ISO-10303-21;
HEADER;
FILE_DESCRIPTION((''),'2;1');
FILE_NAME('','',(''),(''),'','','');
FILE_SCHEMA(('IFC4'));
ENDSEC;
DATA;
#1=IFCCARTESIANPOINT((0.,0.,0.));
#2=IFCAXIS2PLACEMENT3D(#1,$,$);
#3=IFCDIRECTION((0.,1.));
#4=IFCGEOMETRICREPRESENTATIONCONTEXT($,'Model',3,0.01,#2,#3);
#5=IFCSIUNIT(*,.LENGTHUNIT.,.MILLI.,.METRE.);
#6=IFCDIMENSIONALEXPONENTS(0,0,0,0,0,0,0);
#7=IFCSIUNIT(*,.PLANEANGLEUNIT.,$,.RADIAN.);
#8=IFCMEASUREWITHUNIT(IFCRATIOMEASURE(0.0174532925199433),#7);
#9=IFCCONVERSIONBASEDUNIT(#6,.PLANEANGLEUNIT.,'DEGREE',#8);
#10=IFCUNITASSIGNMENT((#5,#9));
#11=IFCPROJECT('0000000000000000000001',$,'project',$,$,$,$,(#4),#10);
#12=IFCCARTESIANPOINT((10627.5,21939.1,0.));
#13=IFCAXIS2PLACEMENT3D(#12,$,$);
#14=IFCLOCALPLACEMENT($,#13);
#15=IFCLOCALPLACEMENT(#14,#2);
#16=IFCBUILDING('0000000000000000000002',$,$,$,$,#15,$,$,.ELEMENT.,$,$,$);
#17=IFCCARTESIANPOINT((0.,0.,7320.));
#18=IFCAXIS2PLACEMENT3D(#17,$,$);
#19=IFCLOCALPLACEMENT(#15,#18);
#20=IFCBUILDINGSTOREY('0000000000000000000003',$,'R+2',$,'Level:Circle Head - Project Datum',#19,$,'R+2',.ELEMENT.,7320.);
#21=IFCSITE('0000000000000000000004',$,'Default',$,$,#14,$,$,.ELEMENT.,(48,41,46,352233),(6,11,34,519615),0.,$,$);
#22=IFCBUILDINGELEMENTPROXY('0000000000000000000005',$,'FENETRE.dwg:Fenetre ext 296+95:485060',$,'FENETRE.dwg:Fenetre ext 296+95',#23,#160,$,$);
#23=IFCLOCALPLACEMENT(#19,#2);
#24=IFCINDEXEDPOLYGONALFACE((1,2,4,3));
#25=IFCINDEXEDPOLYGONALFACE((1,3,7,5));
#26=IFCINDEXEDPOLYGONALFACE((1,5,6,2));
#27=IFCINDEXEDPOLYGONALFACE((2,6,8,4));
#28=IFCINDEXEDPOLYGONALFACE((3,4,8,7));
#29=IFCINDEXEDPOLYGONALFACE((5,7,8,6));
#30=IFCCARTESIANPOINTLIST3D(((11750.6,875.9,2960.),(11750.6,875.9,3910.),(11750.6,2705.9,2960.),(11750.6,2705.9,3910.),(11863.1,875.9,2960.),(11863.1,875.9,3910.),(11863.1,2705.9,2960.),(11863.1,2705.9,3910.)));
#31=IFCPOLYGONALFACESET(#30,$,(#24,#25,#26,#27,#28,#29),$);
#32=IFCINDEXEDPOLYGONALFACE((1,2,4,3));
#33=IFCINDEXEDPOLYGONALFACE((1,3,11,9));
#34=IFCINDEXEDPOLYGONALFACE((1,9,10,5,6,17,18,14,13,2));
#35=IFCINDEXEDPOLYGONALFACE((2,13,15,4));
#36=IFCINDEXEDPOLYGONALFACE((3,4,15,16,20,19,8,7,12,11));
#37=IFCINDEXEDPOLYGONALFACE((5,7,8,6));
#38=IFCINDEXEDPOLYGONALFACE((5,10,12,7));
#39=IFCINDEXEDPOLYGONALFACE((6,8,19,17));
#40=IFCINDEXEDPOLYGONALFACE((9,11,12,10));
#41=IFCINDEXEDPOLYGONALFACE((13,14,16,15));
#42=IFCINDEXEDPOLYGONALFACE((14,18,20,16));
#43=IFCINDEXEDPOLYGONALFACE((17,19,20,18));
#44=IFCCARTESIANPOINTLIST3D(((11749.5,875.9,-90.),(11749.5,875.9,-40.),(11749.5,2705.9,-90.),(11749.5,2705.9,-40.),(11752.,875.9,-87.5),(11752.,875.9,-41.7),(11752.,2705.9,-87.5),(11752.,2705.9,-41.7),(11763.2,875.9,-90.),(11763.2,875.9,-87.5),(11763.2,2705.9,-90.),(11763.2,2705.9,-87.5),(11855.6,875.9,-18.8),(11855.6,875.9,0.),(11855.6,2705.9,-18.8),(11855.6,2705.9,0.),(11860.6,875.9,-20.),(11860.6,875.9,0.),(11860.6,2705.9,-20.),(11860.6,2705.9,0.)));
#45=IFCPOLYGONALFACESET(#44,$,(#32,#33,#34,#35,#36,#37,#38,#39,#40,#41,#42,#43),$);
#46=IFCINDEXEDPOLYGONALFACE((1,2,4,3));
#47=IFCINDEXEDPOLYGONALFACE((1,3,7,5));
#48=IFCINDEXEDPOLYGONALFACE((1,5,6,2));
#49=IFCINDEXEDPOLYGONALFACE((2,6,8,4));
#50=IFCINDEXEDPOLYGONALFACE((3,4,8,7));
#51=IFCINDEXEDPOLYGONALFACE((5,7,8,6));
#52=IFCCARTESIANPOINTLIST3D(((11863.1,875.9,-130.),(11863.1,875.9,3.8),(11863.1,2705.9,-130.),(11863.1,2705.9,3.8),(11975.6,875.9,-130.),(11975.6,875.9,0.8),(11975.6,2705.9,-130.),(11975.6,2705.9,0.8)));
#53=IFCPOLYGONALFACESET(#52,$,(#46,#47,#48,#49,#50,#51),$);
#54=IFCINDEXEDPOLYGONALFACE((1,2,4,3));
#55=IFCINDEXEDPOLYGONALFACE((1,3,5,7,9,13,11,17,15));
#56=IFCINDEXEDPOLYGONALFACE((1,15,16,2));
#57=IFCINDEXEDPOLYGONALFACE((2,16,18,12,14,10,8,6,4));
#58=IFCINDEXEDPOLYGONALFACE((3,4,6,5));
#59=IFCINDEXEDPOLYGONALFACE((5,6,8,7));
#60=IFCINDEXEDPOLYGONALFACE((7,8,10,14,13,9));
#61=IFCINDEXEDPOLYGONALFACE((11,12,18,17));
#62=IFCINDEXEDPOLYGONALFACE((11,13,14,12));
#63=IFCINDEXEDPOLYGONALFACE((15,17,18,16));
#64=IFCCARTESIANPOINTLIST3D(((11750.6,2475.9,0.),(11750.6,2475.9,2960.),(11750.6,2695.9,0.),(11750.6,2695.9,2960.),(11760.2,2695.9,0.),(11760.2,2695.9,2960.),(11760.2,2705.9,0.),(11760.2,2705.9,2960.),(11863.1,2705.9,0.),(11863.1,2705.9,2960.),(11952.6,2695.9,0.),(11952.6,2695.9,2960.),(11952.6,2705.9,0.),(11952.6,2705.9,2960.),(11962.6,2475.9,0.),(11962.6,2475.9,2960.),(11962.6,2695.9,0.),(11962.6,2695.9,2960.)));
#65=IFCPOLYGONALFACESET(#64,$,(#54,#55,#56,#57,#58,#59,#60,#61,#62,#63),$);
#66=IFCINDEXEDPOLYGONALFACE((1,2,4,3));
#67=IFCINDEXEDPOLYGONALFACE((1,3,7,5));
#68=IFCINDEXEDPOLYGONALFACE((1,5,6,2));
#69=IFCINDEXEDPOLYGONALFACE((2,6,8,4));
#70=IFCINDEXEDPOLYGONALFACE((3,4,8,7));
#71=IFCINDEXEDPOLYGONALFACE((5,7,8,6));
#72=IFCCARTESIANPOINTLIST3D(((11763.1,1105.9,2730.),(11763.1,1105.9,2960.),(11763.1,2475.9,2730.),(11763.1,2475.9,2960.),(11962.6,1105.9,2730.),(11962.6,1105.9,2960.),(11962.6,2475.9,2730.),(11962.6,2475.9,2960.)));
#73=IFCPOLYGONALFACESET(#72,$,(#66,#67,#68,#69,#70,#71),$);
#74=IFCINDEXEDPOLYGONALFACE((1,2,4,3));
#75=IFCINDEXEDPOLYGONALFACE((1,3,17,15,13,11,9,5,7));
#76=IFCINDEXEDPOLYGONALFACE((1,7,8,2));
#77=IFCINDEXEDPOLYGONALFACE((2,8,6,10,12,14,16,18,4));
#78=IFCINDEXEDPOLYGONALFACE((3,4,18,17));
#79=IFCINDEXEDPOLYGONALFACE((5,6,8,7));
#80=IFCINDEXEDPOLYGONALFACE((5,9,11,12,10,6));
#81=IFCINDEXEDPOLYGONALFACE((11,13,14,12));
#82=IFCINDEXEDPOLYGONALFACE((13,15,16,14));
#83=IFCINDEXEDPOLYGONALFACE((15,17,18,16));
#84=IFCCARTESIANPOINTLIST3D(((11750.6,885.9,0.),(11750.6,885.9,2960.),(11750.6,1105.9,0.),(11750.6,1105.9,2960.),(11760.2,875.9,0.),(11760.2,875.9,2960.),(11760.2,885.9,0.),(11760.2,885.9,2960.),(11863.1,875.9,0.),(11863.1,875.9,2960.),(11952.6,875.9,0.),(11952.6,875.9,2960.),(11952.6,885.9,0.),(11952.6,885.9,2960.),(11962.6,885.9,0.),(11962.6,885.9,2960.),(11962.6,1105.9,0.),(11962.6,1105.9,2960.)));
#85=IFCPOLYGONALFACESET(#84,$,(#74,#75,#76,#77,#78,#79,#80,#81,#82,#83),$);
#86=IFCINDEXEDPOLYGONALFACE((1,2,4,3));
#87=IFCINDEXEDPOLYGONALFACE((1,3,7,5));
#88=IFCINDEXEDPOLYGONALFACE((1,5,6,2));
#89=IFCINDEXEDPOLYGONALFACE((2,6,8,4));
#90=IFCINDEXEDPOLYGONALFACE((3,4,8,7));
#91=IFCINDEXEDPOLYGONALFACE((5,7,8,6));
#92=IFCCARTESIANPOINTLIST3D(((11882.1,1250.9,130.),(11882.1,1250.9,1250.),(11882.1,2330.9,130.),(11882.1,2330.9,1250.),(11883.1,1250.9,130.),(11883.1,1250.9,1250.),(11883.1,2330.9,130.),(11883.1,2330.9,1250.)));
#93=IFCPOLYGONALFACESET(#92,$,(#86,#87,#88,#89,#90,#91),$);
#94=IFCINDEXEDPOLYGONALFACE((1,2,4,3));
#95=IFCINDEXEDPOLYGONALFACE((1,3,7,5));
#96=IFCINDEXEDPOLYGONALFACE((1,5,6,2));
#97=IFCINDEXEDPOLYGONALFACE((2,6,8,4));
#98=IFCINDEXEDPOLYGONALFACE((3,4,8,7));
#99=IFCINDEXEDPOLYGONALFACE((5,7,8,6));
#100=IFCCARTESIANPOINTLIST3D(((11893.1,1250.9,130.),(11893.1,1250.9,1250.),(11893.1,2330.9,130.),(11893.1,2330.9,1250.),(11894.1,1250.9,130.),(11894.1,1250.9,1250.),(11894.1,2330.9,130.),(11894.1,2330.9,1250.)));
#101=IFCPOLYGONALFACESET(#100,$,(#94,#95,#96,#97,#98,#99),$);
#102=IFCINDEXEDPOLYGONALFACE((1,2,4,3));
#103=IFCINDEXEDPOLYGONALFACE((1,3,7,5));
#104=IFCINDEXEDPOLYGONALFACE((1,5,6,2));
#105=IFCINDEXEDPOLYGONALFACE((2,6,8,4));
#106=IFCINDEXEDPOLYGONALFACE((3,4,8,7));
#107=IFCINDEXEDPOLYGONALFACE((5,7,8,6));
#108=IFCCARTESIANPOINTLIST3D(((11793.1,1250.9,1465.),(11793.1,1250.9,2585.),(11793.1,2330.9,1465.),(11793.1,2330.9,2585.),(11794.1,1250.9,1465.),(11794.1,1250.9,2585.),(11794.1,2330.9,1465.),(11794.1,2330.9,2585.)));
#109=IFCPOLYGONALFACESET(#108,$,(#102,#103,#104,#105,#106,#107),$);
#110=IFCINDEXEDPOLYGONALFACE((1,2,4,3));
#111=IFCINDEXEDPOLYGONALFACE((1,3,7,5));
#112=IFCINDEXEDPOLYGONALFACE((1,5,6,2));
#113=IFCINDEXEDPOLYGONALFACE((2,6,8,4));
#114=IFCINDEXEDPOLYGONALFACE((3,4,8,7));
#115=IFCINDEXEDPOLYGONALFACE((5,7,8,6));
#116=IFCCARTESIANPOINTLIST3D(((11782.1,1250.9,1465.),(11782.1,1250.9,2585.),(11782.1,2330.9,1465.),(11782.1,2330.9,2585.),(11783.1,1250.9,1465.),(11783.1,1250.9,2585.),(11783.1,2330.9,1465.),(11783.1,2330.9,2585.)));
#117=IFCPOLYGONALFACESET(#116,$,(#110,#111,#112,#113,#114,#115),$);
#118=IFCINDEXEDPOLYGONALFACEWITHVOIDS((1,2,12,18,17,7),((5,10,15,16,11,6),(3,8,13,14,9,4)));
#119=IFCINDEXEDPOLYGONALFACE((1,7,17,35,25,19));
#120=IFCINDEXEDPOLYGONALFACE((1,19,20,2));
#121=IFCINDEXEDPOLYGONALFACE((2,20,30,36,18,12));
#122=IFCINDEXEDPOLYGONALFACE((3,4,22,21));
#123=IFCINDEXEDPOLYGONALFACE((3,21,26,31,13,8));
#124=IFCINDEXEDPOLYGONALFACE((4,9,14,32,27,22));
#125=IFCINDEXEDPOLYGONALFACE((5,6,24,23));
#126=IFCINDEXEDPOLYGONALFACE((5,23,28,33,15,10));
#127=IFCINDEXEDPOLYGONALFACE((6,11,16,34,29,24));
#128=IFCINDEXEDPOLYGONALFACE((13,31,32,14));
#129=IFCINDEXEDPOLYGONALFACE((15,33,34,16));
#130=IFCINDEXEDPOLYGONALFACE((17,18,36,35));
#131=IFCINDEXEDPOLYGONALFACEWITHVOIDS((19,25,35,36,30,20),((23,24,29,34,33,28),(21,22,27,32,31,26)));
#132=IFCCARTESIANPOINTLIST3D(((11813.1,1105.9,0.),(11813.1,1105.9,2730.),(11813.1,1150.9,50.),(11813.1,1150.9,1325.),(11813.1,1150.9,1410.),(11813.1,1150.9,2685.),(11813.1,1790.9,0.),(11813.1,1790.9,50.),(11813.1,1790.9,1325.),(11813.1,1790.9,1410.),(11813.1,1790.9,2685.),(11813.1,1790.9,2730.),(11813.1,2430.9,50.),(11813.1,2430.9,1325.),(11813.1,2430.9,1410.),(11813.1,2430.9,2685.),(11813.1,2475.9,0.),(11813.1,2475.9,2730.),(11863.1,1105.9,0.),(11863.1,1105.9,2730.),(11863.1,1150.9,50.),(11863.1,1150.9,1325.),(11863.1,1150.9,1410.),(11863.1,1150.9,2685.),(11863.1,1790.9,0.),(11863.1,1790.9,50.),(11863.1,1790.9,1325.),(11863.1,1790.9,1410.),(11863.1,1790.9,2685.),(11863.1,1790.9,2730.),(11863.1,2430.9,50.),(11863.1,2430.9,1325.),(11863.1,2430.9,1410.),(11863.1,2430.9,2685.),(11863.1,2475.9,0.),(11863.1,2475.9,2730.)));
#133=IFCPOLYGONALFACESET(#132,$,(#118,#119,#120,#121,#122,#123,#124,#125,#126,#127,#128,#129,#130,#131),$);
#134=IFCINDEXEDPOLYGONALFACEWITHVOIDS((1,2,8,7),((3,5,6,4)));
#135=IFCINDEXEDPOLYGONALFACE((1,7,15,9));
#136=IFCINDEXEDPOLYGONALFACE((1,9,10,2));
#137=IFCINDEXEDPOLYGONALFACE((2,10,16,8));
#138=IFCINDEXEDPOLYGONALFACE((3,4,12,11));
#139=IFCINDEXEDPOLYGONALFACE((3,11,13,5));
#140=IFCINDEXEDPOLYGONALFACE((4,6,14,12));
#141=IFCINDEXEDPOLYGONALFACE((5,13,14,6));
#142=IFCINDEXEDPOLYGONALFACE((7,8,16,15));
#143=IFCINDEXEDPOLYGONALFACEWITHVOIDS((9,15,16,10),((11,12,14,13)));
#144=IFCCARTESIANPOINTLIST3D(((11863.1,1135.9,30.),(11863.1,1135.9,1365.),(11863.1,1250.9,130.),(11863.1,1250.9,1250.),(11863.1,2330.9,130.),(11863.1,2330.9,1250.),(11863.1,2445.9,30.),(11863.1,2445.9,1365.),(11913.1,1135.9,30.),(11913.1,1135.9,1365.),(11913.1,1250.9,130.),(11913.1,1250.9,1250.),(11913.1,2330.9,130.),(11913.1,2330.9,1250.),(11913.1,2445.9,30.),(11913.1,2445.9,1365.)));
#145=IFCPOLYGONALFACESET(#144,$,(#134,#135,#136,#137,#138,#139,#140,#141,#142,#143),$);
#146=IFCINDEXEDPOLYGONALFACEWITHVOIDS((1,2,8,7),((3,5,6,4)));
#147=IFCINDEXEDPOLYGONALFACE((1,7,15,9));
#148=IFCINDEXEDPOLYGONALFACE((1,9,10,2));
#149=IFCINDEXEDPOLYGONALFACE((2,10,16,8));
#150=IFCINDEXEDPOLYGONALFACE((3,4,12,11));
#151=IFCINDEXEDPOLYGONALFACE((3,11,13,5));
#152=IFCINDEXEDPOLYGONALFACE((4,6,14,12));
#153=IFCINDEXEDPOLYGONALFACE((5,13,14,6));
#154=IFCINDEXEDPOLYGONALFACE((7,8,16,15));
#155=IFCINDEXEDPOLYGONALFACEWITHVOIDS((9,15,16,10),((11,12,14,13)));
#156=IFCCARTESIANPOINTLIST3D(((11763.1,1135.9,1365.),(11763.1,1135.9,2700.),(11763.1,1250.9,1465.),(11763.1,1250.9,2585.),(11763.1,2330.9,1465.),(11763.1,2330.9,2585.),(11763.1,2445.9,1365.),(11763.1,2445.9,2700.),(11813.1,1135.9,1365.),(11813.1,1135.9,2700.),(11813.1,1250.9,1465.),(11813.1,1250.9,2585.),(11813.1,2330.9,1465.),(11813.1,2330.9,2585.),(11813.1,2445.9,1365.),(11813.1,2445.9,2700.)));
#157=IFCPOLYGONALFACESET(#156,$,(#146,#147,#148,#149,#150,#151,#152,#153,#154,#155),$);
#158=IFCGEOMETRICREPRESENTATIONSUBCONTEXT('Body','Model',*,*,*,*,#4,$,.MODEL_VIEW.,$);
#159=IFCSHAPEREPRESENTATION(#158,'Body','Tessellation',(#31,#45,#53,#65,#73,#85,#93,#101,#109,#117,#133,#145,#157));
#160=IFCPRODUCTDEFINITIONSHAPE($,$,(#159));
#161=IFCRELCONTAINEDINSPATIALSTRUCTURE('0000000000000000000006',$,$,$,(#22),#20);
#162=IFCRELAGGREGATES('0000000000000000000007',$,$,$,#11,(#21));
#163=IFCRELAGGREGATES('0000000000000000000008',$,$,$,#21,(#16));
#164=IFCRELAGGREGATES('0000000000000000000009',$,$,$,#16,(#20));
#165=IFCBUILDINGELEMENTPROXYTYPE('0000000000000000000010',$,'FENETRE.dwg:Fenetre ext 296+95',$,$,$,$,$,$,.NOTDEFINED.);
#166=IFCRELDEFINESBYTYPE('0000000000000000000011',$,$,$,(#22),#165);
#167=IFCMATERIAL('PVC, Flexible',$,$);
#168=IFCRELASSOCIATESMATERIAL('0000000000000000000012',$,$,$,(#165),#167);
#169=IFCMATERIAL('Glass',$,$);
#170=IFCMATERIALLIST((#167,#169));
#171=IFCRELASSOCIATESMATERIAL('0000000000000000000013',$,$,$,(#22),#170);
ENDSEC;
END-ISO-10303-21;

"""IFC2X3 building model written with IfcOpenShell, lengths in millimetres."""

from ifc_helpers import new_model, entity, si_unit, converted_unit, direction, frame, frame_2d, origin, origin_2d_with_axis, place, context, subcontext, project, spatial, polyline, rectangle, outline, extrude, source, transform, mapped, material, material_list, type_object, type_shapes, element, save


model = new_model("IFC2X3")

# Units and contexts
model_context = context("Model", 3, precision=0.01, world=origin(), true_north=direction((0.0, 1.0)))
body_context = subcontext(model_context, "Body", "Model", "MODEL_VIEW")
ifc_project = project(units=[si_unit("LENGTHUNIT", "METRE", prefix="MILLI"), converted_unit("PLANEANGLEUNIT", "DEGREE", entity("IfcRatioMeasure", 0.0174532925199433), si_unit("PLANEANGLEUNIT", "RADIAN"), dimensions=[0, 0, 0, 0, 0, 0, 0])], contexts=[model_context])

# Site, building, storey
site_placement = place(None, frame((10627.5, 21939.1, 0.0)))
site = spatial("IfcSite", under=ifc_project, at=site_placement, Name="Default", CompositionType="ELEMENT", RefLatitude=(48, 41, 46, 352233), RefLongitude=(6, 11, 34, 519615), RefElevation=0.0)
building_placement = place(site_placement, origin())
building = spatial("IfcBuilding", under=site, at=building_placement, CompositionType="ELEMENT")
storey_placement = place(building_placement, frame((0.0, 0.0, 7320.0)))
storey = spatial("IfcBuildingStorey", under=building, at=storey_placement, Name="R+2", ObjectType="Level:Circle Head - Project Datum", LongName="R+2", CompositionType="ELEMENT", Elevation=7320.0)

# Building element proxy
ifc_material_1 = material(Name="PVC, Flexible")
ifc_material_2 = material(Name="Glass")
building_element_proxy_type_1 = type_object("IfcBuildingElementProxyType", Name="FENETRE.dwg:Fenetre ext 296+95", PredefinedType="NOTDEFINED", material=ifc_material_1)
shared_shape_1 = source(origin(), body_context, "Body", "SweptSolid", [
    extrude(rectangle(XDim=1830.0, YDim=112.5, at=origin_2d_with_axis()), frame((-10.4, 56.3, 2960.0), z_axis=(0.0, 0.0, 1.0), x_axis=(-1.0, 0.0, 0.0)), (0.0, 0.0, 1.0), 950.0),
    extrude(outline(polyline([(-68.6, -14.4), (-72.5, -34.0), (-67.6, -35.0), (-63.9, -16.6), (44.3, -16.6), (54.1, 32.5), (40.6, 35.2), (40.1, 32.7), (51.2, 30.5), (42.2, -14.4), (-68.6, -14.4)])), frame((-925.4, 66.9, -47.5), z_axis=(-1.0, 0.0, 0.0), x_axis=(0.0, 0.980599, -0.196027)), (0.0, 0.0, -1.0), 1830.0),
    extrude(outline(polyline([(-64.7, -56.3), (66.2, -56.3), (66.2, 56.3), (-67.7, 56.3), (-64.7, -56.3)])), frame((-925.4, -56.3, -63.8), z_axis=(1.0, 0.0, 0.0), x_axis=(0.0, 0.0, -1.0)), (0.0, 0.0, 1.0), 1830.0),
    extrude(outline(polyline([(-55.6, 97.0), (-55.6, -5.9), (-55.6, -95.4), (-45.6, -95.4), (-45.6, -105.4), (174.4, -105.4), (174.4, 106.6), (-45.6, 106.6), (-45.6, 97.0), (-55.6, 97.0)])), frame((849.0, 5.9, 0.0), z_axis=(0.0, 0.0, -1.0), x_axis=(-1.0, 0.0, 0.0)), (0.0, 0.0, -1.0), 2960.0),
    extrude(rectangle(XDim=199.5, YDim=1370.0, at=origin_2d_with_axis()), frame((-10.4, 0.3, 2730.0), z_axis=(0.0, 0.0, 1.0), x_axis=(0.0, 1.0, 0.0)), (0.0, 0.0, 1.0), 230.0),
    extrude(outline(polyline([(-97.0, -55.6), (5.9, -55.6), (95.4, -55.6), (95.4, -45.6), (105.4, -45.6), (105.4, 174.4), (-106.6, 174.4), (-106.6, -45.6), (-97.0, -45.6), (-97.0, -55.6)])), frame((-869.9, 5.9, 0.0), z_axis=(0.0, 0.0, 1.0), x_axis=(0.0, -1.0, 0.0)), (0.0, 0.0, 1.0), 2960.0),
    extrude(rectangle(XDim=1.0, YDim=1080.0, at=origin_2d_with_axis()), frame((-10.4, -19.5, 130.0), z_axis=(0.0, 0.0, 1.0), x_axis=(0.0, 1.0, 0.0)), (0.0, 0.0, 1.0), 1120.0),
    extrude(rectangle(XDim=1.0, YDim=1080.0, at=frame_2d((0.0, 0.0), x_axis=(1.0, 0.0))), frame((-10.4, -30.5, 130.0), z_axis=(0.0, 0.0, 1.0), x_axis=(0.0, 1.0, 0.0)), (0.0, 0.0, 1.0), 1120.0),
    extrude(rectangle(XDim=1.0, YDim=1080.0, at=frame_2d((0.0, 0.0), x_axis=(1.0, 0.0))), frame((-10.4, 69.5, 1465.0), z_axis=(0.0, 0.0, 1.0), x_axis=(0.0, 1.0, 0.0)), (0.0, 0.0, 1.0), 1120.0),
    extrude(rectangle(XDim=1.0, YDim=1080.0, at=frame_2d((0.0, 0.0), x_axis=(1.0, 0.0))), frame((-10.4, 80.5, 1465.0), z_axis=(0.0, 0.0, 1.0), x_axis=(0.0, 1.0, 0.0)), (0.0, 0.0, 1.0), 1120.0),
    extrude(outline(polyline([(-685.0, -1365.0), (0.0, -1365.0), (685.0, -1365.0), (685.0, 1365.0), (0.0, 1365.0), (-685.0, 1365.0), (-685.0, -1365.0)]), holes=[polyline([(-640.0, -1320.0), (-640.0, -45.0), (0.0, -45.0), (640.0, -45.0), (640.0, -1320.0), (0.0, -1320.0), (-640.0, -1320.0)]), polyline([(-640.0, 40.0), (-640.0, 1315.0), (0.0, 1315.0), (640.0, 1315.0), (640.0, 40.0), (0.0, 40.0), (-640.0, 40.0)])]), frame((-10.4, 0.0, 1365.0), z_axis=(0.0, 1.0, 0.0), x_axis=(1.0, 0.0, 0.0)), (0.0, 0.0, 1.0), 50.0),
    extrude(outline(polyline([(-655.0, -667.5), (655.0, -667.5), (655.0, 667.5), (-655.0, 667.5), (-655.0, -667.5)]), holes=[polyline([(-540.0, 552.5), (540.0, 552.5), (540.0, -567.5), (-540.0, -567.5), (-540.0, 552.5)])]), frame((-10.4, -50.0, 697.5), z_axis=(0.0, 1.0, 0.0), x_axis=(-1.0, 0.0, 0.0)), (0.0, 0.0, 1.0), 50.0),
    extrude(outline(polyline([(-655.0, -667.5), (655.0, -667.5), (655.0, 667.5), (-655.0, 667.5), (-655.0, -667.5)]), holes=[polyline([(-540.0, 552.5), (540.0, 552.5), (540.0, -567.5), (-540.0, -567.5), (-540.0, 552.5)])]), frame((-10.4, 50.0, 2032.5), z_axis=(0.0, 1.0, 0.0), x_axis=(-1.0, 0.0, 0.0)), (0.0, 0.0, 1.0), 50.0),
])
type_shapes(building_element_proxy_type_1, [shared_shape_1])
ifc_material_list_1 = material_list([ifc_material_1, ifc_material_2])
proxy_1_placement = place(storey_placement, frame((11863.1, 1801.3, 0.0), z_axis=(0.0, 0.0, 1.0), x_axis=(0.0, 1.0, 0.0)))
element("IfcBuildingElementProxy", 1, at=proxy_1_placement, inside=storey, type_object=building_element_proxy_type_1, material=ifc_material_list_1, Name="FENETRE.dwg:Fenetre ext 296+95:485060", ObjectType="FENETRE.dwg:Fenetre ext 296+95", context=body_context, shape_type="MappedRepresentation", body=[
    mapped(shared_shape_1, transform((0.0, 0.0, 0.0), scale=1.0)),
])

save(model, "model.ifc")
